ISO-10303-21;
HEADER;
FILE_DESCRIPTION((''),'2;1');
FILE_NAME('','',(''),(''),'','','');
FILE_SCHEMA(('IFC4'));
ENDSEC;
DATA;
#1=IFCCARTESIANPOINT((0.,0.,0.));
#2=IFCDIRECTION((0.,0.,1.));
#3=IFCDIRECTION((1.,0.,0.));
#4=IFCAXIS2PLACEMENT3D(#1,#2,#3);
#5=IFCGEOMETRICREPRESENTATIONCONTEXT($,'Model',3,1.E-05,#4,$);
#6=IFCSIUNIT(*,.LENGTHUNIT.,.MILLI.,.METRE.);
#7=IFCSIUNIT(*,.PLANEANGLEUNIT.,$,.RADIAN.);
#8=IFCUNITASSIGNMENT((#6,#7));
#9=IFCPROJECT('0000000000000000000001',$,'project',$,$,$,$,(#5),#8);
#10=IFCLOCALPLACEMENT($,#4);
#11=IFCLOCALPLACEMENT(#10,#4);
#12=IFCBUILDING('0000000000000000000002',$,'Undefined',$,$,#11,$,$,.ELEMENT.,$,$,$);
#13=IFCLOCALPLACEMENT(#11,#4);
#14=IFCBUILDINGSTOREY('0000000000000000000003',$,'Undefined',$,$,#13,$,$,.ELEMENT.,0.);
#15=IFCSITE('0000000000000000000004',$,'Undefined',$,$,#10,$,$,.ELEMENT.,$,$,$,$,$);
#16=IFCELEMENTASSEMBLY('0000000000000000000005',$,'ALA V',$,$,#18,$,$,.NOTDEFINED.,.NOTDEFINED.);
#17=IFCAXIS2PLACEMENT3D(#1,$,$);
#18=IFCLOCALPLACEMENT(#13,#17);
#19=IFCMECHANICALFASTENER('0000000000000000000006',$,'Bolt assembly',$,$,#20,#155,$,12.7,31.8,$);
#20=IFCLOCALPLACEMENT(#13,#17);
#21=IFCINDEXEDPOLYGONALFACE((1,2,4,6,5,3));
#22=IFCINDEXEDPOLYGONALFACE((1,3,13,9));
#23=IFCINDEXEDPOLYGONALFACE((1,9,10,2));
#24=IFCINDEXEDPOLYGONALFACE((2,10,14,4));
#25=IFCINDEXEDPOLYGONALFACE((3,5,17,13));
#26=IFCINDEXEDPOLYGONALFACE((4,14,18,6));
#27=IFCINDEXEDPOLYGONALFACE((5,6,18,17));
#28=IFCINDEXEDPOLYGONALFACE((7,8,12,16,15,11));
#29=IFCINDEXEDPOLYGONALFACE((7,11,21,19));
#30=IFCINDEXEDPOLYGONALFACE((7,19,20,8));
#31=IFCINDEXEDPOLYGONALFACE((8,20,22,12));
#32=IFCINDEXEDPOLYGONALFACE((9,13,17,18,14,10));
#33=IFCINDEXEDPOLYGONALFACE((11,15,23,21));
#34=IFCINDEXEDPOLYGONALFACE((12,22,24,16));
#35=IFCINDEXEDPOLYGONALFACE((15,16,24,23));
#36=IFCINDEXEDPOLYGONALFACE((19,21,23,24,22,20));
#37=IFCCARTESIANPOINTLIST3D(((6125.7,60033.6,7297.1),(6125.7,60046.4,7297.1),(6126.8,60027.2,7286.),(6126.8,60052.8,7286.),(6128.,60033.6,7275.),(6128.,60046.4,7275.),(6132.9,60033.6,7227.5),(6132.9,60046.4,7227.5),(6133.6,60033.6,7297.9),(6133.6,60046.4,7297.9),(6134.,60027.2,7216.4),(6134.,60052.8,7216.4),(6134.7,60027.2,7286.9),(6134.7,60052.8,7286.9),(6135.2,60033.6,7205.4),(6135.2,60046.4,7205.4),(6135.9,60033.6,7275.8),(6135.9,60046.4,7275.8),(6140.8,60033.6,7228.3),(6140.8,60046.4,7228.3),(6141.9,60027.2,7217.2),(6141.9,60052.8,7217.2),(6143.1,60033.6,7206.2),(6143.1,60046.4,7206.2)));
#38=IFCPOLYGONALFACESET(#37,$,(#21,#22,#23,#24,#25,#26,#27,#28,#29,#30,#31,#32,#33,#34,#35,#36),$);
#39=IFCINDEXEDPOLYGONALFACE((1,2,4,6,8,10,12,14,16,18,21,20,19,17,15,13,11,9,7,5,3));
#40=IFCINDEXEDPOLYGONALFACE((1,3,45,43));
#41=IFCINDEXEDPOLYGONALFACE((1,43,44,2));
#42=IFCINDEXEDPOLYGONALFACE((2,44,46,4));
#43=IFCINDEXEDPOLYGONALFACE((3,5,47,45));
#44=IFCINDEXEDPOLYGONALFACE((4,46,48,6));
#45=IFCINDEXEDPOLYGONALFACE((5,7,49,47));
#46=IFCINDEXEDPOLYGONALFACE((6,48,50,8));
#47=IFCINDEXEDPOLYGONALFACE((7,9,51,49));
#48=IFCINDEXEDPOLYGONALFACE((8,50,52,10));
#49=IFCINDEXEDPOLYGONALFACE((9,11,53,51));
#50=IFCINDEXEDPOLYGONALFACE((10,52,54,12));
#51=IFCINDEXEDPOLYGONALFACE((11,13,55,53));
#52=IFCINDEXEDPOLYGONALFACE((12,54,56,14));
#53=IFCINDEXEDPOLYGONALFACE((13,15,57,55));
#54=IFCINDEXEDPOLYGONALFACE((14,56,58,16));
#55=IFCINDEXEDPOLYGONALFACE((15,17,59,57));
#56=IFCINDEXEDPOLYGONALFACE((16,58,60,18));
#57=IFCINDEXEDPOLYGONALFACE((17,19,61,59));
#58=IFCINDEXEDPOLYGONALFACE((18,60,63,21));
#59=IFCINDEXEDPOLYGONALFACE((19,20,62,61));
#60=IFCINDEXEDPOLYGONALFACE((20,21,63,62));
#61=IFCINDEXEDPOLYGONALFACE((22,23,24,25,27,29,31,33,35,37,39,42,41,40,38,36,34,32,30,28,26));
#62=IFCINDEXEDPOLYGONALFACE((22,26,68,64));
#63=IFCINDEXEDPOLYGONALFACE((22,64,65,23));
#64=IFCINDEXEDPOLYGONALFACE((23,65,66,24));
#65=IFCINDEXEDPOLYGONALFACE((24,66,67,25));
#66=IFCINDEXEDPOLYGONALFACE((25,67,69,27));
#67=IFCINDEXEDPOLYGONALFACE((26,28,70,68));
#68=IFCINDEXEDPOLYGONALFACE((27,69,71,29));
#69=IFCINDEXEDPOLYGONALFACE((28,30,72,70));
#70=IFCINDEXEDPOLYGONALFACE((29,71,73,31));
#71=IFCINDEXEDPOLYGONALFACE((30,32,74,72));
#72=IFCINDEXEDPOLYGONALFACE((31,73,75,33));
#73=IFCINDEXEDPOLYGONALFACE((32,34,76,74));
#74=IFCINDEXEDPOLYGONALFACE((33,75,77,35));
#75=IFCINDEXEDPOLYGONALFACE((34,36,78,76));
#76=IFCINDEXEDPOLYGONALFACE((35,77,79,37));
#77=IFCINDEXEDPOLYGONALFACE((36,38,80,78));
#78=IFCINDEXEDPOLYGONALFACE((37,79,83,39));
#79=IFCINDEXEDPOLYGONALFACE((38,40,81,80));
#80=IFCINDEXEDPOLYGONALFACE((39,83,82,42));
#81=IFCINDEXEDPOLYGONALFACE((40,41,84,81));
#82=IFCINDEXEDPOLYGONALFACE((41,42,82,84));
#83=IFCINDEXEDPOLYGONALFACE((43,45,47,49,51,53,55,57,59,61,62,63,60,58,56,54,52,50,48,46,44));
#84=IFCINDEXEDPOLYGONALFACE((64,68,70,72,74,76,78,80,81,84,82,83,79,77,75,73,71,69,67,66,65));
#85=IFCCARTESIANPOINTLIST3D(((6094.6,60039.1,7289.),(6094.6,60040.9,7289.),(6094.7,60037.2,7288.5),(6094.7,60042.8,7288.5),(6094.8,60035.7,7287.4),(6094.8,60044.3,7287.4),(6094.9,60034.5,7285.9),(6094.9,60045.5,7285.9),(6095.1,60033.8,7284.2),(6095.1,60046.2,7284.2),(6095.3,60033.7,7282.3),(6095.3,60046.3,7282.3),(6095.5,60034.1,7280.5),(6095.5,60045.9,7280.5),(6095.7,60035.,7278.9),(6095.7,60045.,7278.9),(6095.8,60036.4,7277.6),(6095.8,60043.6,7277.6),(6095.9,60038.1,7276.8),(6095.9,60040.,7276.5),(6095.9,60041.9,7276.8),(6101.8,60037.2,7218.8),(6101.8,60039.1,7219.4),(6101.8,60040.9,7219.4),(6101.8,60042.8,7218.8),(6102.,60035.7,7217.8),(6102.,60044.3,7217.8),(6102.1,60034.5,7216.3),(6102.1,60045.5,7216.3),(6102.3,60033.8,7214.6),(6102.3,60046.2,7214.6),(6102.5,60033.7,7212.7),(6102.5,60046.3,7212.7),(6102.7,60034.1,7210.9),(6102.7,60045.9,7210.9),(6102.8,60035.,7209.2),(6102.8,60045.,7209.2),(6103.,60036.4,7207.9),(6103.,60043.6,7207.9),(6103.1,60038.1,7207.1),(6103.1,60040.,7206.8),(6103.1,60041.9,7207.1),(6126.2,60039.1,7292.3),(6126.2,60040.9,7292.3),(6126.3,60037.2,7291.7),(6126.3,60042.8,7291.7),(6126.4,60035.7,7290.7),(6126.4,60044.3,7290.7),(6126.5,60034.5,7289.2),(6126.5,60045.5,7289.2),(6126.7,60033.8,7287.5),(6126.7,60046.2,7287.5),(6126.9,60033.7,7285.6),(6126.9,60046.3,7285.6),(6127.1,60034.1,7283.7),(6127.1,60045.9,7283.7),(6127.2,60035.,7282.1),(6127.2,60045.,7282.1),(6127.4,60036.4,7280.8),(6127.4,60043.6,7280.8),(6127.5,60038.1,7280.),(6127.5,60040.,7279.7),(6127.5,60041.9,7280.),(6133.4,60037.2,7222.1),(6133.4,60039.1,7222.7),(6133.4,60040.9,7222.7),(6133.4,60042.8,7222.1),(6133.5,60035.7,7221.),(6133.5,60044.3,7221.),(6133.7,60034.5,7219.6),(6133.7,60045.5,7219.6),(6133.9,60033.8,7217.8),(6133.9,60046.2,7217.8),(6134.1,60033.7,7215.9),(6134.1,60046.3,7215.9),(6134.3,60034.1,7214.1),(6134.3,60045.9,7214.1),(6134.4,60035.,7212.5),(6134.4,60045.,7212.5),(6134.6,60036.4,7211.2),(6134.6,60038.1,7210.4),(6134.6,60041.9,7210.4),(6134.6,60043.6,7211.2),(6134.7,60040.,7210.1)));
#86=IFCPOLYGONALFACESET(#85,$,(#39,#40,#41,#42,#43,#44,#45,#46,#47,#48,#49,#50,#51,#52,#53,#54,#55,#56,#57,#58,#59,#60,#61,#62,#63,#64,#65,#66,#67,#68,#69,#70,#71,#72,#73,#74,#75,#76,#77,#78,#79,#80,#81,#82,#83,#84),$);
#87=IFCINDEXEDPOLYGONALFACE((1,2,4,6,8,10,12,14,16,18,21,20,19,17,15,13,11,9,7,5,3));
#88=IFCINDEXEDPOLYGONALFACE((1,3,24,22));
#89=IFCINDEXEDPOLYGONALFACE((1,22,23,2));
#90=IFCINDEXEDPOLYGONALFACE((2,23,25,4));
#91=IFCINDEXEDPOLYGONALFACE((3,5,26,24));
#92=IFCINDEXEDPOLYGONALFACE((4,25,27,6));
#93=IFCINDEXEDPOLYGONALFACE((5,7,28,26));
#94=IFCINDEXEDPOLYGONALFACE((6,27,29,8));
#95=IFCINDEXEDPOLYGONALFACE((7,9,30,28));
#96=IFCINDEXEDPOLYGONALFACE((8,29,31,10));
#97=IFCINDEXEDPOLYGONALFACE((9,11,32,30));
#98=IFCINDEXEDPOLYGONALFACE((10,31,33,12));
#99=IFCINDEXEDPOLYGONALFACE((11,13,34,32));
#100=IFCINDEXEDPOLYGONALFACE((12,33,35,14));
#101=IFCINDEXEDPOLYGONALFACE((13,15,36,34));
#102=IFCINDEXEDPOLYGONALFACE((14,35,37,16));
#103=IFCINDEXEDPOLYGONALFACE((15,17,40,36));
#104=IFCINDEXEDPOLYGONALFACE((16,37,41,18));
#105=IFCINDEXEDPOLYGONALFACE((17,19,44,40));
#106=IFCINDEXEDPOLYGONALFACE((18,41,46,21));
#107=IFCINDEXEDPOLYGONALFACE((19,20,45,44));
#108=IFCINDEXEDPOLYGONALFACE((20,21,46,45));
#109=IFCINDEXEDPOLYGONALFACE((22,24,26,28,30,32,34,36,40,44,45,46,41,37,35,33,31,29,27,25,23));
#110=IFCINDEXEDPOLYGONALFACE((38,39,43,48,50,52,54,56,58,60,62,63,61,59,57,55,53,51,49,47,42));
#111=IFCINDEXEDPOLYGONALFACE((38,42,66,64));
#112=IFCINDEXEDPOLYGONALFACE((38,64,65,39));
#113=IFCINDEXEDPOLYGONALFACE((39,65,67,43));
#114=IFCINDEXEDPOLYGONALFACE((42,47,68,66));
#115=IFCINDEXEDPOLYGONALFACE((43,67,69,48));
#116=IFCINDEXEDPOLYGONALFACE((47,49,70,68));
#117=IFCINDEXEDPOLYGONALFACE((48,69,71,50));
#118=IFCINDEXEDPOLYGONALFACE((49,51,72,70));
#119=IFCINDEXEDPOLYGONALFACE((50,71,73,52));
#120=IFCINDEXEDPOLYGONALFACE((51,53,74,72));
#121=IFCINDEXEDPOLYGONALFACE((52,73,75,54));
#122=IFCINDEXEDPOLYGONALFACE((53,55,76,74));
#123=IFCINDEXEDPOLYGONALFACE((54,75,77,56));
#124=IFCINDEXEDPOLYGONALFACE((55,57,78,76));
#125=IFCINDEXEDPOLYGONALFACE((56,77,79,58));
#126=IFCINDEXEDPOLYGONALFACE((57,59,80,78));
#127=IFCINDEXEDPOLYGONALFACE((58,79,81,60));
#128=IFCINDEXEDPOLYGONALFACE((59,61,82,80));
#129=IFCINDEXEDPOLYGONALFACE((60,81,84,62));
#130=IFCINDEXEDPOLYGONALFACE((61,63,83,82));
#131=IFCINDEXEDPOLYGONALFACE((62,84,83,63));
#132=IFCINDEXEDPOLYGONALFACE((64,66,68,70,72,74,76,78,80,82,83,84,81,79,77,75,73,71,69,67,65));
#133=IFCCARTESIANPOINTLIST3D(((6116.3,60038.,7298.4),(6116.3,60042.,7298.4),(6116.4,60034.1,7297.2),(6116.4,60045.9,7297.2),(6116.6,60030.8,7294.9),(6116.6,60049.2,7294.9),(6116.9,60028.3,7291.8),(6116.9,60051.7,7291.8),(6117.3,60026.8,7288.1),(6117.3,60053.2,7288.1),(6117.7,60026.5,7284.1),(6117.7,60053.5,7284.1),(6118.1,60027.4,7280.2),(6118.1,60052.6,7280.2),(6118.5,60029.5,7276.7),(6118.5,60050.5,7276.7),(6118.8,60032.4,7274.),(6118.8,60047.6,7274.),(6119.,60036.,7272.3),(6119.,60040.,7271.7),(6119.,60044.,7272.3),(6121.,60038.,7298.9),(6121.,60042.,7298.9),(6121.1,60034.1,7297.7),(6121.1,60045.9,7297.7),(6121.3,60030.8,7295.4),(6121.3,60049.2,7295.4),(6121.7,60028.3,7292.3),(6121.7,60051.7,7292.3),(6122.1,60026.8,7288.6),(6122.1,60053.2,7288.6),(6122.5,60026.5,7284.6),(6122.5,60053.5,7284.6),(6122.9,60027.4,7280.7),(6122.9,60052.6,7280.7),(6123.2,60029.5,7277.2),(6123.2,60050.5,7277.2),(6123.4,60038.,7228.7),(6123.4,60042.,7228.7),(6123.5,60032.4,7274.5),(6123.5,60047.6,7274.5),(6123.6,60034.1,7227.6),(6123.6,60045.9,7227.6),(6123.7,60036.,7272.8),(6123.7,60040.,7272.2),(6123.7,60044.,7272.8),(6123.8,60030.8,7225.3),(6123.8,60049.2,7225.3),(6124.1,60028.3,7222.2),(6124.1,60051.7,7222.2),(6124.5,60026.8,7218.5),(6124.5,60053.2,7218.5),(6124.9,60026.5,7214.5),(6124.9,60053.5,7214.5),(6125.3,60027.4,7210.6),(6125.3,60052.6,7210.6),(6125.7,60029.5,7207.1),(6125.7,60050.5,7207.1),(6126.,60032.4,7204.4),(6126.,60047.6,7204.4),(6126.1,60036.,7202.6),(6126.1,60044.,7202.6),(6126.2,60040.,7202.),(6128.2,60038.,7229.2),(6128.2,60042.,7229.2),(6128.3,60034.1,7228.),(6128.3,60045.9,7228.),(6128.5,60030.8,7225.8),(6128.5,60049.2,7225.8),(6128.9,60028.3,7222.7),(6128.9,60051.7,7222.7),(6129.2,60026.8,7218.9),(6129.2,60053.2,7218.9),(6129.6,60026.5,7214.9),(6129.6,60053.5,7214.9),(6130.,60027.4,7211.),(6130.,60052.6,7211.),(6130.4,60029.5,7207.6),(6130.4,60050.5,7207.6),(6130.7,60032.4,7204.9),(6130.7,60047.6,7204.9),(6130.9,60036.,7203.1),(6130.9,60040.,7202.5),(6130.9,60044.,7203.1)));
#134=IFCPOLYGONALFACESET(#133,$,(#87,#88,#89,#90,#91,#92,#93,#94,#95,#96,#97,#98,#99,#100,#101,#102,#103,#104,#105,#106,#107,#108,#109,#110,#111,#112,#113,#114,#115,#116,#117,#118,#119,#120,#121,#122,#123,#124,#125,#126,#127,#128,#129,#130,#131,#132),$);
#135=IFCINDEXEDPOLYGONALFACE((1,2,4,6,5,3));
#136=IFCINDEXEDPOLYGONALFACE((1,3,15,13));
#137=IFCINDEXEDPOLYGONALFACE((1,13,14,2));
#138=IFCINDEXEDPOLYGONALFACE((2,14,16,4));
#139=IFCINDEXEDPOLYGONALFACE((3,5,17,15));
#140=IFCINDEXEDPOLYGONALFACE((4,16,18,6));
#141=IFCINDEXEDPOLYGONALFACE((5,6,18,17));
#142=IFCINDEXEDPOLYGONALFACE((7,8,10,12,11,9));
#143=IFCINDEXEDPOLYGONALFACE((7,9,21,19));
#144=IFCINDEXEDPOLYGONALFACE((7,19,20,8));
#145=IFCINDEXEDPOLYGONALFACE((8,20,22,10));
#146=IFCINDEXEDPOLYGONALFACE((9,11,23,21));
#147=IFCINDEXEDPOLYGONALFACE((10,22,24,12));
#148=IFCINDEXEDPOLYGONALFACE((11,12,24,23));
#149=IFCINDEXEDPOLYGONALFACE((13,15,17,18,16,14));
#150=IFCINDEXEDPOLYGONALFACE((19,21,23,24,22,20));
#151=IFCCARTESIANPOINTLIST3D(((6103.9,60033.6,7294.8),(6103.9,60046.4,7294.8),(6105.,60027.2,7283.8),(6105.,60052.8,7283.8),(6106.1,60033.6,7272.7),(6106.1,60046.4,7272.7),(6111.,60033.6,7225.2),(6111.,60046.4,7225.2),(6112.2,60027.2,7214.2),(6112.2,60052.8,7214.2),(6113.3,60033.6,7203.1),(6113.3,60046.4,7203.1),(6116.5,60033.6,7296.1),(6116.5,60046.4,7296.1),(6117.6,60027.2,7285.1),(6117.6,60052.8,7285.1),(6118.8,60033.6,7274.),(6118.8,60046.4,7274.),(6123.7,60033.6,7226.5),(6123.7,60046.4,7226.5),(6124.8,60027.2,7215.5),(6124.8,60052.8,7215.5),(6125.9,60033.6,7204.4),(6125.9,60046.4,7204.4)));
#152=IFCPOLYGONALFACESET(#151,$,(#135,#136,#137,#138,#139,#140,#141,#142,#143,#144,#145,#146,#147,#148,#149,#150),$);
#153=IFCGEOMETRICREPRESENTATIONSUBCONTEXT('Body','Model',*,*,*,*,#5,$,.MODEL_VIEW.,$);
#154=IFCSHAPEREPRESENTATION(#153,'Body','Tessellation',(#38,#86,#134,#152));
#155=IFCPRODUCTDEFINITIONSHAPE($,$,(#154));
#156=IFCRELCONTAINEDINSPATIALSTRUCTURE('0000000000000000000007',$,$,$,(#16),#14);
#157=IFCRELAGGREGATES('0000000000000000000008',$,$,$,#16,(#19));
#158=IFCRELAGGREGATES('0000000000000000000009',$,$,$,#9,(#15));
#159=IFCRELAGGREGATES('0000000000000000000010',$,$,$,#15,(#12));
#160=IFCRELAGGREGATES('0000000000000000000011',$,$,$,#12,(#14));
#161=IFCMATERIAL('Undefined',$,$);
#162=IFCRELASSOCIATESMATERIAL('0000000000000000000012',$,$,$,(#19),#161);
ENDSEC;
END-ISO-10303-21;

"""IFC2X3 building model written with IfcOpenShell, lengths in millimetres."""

from ifc_helpers import new_model, si_unit, frame, origin_with_axes, origin_2d_with_axis, place, context, subcontext, project, spatial, polyline, circle, outline, extrude, source, transform, mapped, material, element, aggregate, save


model = new_model("IFC2X3")

# Units and contexts
model_context = context("Model", 3, precision=1e-05, world=origin_with_axes())
body_context = subcontext(model_context, "Body", "Model", "MODEL_VIEW")
ifc_project = project(units=[si_unit("LENGTHUNIT", "METRE", prefix="MILLI"), si_unit("PLANEANGLEUNIT", "RADIAN")], contexts=[model_context])

# Site, building, storey
site_placement = place(None, origin_with_axes())
site = spatial("IfcSite", under=ifc_project, at=site_placement, Name="Undefined", CompositionType="ELEMENT")
building_placement = place(site_placement, origin_with_axes())
building = spatial("IfcBuilding", under=site, at=building_placement, Name="Undefined", CompositionType="ELEMENT")
storey_placement = place(building_placement, origin_with_axes())
storey = spatial("IfcBuildingStorey", under=building, at=storey_placement, Name="Undefined", CompositionType="ELEMENT", Elevation=0.0)

# Element assembly
assembly_1_placement = place(storey_placement, origin_with_axes())
assembly_1 = element("IfcElementAssembly", 1, at=assembly_1_placement, inside=storey, Name="ALA V", AssemblyPlace="NOTDEFINED", PredefinedType="NOTDEFINED")

# Mechanical fastener
ifc_material_1 = material(Name="Undefined")
shared_shape_1 = source(origin_with_axes(), body_context, "Body", "SweptSolid", [
    extrude(outline(polyline([(11.1, -6.4), (11.1, 6.4), (0.0, 12.8), (-11.1, 6.4), (-11.1, -6.4), (0.0, -12.8), (11.1, -6.4)])), frame((0.0, -12.4, 0.0), z_axis=(0.0, 1.0, 0.0), x_axis=(1.0, 0.0, 0.0)), (0.0, 0.0, 1.0), 7.9),
    extrude(circle(Radius=6.3, at=origin_2d_with_axis()), frame((0.0, -4.5, 0.0), z_axis=(0.0, 1.0, 0.0), x_axis=(1.0, 0.0, 0.0)), (0.0, 0.0, 1.0), 31.8),
    extrude(circle(Radius=13.5, at=origin_2d_with_axis()), frame((0.0, 0.0, 0.0), z_axis=(0.0, 1.0, 0.0), x_axis=(1.0, 0.0, 0.0)), (0.0, 0.0, 1.0), 4.8),
    extrude(outline(polyline([(11.1, -6.4), (11.1, 6.4), (0.0, 12.8), (-11.1, 6.4), (-11.1, -6.4), (0.0, -12.8), (11.1, -6.4)])), frame((0.0, 4.8, 0.0), z_axis=(0.0, 1.0, 0.0), x_axis=(1.0, 0.0, 0.0)), (0.0, 0.0, 1.0), 12.7),
])
mechanical_fastener_1_placement = place(assembly_1_placement, frame((6122.4, 60040.0, 7285.6), z_axis=(0.0, 1.0, 0.0), x_axis=(0.102562, 0.0, -0.994727)))
mechanical_fastener_1 = element("IfcMechanicalFastener", 2, at=mechanical_fastener_1_placement, material=ifc_material_1, Name="Bolt assembly", NominalDiameter=12.7, NominalLength=31.8, context=body_context, shape_type="MappedRepresentation", body=[
    mapped(shared_shape_1, transform((0.0, 0.0, 0.0))),
    mapped(shared_shape_1, transform((70.0, 0.0, 0.0))),
])
aggregate(assembly_1, [mechanical_fastener_1])

save(model, "model.ifc")
